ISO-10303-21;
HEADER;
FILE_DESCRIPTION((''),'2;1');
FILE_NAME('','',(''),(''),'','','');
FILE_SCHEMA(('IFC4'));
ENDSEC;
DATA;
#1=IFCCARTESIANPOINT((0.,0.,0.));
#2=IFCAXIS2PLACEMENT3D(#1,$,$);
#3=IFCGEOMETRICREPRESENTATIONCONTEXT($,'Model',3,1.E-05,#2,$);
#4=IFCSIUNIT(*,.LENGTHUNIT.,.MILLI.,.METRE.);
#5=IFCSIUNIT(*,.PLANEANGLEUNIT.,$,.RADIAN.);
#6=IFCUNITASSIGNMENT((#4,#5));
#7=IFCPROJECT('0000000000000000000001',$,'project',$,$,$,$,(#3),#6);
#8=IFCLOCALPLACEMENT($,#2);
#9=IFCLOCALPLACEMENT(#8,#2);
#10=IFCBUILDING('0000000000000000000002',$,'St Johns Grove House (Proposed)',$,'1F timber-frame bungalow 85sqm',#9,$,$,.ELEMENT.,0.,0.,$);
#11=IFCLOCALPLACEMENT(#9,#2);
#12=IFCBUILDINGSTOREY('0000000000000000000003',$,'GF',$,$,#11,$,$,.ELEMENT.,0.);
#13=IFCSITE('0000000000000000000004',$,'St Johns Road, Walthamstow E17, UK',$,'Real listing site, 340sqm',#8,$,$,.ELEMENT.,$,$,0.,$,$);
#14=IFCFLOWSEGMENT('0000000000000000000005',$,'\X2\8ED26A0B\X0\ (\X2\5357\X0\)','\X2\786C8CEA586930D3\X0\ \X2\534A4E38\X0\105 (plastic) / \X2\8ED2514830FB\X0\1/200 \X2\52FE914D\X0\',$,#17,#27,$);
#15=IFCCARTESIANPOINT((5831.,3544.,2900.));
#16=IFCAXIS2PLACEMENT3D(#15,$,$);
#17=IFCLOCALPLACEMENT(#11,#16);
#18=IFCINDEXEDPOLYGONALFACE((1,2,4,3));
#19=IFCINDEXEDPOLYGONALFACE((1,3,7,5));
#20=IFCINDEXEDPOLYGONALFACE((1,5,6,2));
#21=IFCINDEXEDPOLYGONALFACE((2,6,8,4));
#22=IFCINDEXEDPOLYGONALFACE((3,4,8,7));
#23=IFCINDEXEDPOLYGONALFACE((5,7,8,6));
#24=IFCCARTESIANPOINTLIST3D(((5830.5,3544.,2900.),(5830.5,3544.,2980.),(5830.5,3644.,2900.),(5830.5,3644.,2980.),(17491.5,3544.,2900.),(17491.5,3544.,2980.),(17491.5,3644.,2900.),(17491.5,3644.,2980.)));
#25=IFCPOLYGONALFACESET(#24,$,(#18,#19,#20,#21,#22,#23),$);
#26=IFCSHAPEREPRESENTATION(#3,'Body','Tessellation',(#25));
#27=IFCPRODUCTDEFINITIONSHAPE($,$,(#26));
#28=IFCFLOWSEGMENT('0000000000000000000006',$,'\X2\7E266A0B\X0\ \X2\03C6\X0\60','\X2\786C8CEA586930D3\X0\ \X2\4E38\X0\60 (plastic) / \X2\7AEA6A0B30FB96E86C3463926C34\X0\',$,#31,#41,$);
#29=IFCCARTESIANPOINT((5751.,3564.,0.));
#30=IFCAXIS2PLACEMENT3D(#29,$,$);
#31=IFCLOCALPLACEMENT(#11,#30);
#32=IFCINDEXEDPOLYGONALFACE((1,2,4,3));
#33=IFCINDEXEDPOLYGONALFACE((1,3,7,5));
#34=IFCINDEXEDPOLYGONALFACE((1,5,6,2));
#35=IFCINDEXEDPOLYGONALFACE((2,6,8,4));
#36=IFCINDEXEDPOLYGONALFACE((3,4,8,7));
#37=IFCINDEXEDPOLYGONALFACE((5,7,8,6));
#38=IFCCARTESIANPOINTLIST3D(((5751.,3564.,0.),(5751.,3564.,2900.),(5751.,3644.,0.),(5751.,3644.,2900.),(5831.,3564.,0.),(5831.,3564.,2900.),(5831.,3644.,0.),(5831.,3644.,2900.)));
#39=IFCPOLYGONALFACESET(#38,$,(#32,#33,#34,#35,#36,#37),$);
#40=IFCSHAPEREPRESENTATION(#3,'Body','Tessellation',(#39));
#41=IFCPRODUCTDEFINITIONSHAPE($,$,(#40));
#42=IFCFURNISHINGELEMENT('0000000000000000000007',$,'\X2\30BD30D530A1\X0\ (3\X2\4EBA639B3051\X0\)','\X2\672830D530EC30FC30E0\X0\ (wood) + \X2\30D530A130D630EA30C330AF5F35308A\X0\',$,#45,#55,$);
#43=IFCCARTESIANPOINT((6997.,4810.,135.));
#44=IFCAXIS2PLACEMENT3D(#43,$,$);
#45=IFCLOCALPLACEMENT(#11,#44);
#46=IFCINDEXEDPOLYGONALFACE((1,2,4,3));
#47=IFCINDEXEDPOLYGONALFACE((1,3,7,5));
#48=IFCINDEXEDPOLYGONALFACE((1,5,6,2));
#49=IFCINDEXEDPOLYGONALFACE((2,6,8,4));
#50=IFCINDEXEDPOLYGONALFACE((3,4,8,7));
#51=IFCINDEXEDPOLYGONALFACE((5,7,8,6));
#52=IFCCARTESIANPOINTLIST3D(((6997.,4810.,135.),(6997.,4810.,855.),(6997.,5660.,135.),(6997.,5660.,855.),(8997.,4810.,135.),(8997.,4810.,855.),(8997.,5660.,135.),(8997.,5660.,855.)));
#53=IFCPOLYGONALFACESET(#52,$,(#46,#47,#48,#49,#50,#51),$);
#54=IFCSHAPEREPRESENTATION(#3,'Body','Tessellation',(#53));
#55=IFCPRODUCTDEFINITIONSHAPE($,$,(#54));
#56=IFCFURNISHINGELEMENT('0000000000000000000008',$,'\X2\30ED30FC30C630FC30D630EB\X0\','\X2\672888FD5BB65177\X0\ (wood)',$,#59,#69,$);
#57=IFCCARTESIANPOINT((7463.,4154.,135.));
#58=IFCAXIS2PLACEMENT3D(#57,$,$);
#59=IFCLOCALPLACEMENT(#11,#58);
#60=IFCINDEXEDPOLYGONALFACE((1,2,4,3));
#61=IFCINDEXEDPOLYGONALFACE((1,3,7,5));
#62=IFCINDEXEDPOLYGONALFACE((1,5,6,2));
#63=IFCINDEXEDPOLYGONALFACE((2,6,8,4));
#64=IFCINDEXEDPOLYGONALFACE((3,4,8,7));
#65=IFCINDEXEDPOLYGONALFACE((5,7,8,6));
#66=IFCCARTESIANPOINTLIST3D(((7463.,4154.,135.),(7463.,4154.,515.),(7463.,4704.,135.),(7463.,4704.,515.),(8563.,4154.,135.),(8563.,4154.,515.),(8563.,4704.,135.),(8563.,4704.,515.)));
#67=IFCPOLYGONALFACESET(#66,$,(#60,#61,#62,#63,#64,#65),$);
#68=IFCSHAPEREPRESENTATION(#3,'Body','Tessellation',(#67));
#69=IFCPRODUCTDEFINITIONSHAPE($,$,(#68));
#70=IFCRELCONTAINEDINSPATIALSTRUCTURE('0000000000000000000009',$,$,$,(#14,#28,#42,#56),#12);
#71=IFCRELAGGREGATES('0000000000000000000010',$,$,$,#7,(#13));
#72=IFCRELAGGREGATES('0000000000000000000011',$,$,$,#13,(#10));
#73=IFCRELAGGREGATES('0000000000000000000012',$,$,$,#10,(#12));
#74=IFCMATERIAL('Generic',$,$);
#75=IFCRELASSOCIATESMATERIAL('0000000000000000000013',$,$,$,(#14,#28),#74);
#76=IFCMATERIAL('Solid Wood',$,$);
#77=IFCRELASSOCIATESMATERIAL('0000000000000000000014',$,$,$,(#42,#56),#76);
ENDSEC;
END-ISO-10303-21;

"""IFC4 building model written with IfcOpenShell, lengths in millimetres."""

from ifc_helpers import new_model, si_unit, frame, frame_2d, origin, place, context, project, spatial, rectangle, extrude, material, element, save


model = new_model("IFC4")

# Units and contexts
model_context = context("Model", 3, precision=1e-05, world=origin())
ifc_project = project(units=[si_unit("LENGTHUNIT", "METRE", prefix="MILLI"), si_unit("PLANEANGLEUNIT", "RADIAN")], contexts=[model_context])

# Site, building, storey
site_placement = place(None, origin())
site = spatial("IfcSite", under=ifc_project, at=site_placement, Name="St Johns Road, Walthamstow E17, UK", ObjectType="Real listing site, 340sqm", CompositionType="ELEMENT", RefElevation=0.0)
building_placement = place(site_placement, origin())
building = spatial("IfcBuilding", under=site, at=building_placement, Name="St Johns Grove House (Proposed)", ObjectType="1F timber-frame bungalow 85sqm", CompositionType="ELEMENT", ElevationOfRefHeight=0.0, ElevationOfTerrain=0.0)
storey_placement = place(building_placement, origin())
storey = spatial("IfcBuildingStorey", under=building, at=storey_placement, Name="GF", CompositionType="ELEMENT", Elevation=0.0)

# Shared definitions
ifc_material_1 = material(Name="Solid Wood")

# Shared definitions
ifc_material_2 = material(Name="Generic")

# Flow segments
flow_segment_1_placement = place(storey_placement, frame((5831.0, 3544.0, 2900.0)))
element("IfcFlowSegment", 1, at=flow_segment_1_placement, inside=storey, material=ifc_material_2, Name="軒樋 (南)", Description="硬質塩ビ 半丸105 (plastic) / 軒先・1/200 勾配", context=model_context, shape_type="SweptSolid", body=[
    extrude(rectangle(XDim=11661.0, YDim=100.0, at=frame_2d((5830.0, 50.0))), frame((5831.0, 3544.0, 2900.0)), (0.0, 0.0, 1.0), 80.0),
])
flow_segment_2_placement = place(storey_placement, frame((5751.0, 3564.0, 0.0)))
element("IfcFlowSegment", 2, at=flow_segment_2_placement, inside=storey, material=ifc_material_2, Name="縦樋 φ60", Description="硬質塩ビ 丸60 (plastic) / 竪樋・雨水排水", context=model_context, shape_type="SweptSolid", body=[
    extrude(rectangle(XDim=80.0, YDim=80.0, at=frame_2d((40.0, 40.0))), frame((5751.0, 3564.0, 0.0)), (0.0, 0.0, 1.0), 2900.0),
])

# Furnishing elements
furnishing_1_placement = place(storey_placement, frame((6997.0, 4810.0, 135.0)))
element("IfcFurnishingElement", 3, at=furnishing_1_placement, inside=storey, material=ifc_material_1, Name="ソファ (3人掛け)", Description="木フレーム (wood) + ファブリック張り", context=model_context, shape_type="SweptSolid", body=[
    extrude(rectangle(XDim=2000.0, YDim=850.0, at=frame_2d((1000.0, 425.0))), frame((6997.0, 4810.0, 135.0)), (0.0, 0.0, 1.0), 720.0),
])
furnishing_2_placement = place(storey_placement, frame((7463.0, 4154.0, 135.0)))
element("IfcFurnishingElement", 4, at=furnishing_2_placement, inside=storey, material=ifc_material_1, Name="ローテーブル", Description="木製家具 (wood)", context=model_context, shape_type="SweptSolid", body=[
    extrude(rectangle(XDim=1100.0, YDim=550.0, at=frame_2d((550.0, 275.0))), frame((7463.0, 4154.0, 135.0)), (0.0, 0.0, 1.0), 380.0),
])

save(model, "model.ifc")
